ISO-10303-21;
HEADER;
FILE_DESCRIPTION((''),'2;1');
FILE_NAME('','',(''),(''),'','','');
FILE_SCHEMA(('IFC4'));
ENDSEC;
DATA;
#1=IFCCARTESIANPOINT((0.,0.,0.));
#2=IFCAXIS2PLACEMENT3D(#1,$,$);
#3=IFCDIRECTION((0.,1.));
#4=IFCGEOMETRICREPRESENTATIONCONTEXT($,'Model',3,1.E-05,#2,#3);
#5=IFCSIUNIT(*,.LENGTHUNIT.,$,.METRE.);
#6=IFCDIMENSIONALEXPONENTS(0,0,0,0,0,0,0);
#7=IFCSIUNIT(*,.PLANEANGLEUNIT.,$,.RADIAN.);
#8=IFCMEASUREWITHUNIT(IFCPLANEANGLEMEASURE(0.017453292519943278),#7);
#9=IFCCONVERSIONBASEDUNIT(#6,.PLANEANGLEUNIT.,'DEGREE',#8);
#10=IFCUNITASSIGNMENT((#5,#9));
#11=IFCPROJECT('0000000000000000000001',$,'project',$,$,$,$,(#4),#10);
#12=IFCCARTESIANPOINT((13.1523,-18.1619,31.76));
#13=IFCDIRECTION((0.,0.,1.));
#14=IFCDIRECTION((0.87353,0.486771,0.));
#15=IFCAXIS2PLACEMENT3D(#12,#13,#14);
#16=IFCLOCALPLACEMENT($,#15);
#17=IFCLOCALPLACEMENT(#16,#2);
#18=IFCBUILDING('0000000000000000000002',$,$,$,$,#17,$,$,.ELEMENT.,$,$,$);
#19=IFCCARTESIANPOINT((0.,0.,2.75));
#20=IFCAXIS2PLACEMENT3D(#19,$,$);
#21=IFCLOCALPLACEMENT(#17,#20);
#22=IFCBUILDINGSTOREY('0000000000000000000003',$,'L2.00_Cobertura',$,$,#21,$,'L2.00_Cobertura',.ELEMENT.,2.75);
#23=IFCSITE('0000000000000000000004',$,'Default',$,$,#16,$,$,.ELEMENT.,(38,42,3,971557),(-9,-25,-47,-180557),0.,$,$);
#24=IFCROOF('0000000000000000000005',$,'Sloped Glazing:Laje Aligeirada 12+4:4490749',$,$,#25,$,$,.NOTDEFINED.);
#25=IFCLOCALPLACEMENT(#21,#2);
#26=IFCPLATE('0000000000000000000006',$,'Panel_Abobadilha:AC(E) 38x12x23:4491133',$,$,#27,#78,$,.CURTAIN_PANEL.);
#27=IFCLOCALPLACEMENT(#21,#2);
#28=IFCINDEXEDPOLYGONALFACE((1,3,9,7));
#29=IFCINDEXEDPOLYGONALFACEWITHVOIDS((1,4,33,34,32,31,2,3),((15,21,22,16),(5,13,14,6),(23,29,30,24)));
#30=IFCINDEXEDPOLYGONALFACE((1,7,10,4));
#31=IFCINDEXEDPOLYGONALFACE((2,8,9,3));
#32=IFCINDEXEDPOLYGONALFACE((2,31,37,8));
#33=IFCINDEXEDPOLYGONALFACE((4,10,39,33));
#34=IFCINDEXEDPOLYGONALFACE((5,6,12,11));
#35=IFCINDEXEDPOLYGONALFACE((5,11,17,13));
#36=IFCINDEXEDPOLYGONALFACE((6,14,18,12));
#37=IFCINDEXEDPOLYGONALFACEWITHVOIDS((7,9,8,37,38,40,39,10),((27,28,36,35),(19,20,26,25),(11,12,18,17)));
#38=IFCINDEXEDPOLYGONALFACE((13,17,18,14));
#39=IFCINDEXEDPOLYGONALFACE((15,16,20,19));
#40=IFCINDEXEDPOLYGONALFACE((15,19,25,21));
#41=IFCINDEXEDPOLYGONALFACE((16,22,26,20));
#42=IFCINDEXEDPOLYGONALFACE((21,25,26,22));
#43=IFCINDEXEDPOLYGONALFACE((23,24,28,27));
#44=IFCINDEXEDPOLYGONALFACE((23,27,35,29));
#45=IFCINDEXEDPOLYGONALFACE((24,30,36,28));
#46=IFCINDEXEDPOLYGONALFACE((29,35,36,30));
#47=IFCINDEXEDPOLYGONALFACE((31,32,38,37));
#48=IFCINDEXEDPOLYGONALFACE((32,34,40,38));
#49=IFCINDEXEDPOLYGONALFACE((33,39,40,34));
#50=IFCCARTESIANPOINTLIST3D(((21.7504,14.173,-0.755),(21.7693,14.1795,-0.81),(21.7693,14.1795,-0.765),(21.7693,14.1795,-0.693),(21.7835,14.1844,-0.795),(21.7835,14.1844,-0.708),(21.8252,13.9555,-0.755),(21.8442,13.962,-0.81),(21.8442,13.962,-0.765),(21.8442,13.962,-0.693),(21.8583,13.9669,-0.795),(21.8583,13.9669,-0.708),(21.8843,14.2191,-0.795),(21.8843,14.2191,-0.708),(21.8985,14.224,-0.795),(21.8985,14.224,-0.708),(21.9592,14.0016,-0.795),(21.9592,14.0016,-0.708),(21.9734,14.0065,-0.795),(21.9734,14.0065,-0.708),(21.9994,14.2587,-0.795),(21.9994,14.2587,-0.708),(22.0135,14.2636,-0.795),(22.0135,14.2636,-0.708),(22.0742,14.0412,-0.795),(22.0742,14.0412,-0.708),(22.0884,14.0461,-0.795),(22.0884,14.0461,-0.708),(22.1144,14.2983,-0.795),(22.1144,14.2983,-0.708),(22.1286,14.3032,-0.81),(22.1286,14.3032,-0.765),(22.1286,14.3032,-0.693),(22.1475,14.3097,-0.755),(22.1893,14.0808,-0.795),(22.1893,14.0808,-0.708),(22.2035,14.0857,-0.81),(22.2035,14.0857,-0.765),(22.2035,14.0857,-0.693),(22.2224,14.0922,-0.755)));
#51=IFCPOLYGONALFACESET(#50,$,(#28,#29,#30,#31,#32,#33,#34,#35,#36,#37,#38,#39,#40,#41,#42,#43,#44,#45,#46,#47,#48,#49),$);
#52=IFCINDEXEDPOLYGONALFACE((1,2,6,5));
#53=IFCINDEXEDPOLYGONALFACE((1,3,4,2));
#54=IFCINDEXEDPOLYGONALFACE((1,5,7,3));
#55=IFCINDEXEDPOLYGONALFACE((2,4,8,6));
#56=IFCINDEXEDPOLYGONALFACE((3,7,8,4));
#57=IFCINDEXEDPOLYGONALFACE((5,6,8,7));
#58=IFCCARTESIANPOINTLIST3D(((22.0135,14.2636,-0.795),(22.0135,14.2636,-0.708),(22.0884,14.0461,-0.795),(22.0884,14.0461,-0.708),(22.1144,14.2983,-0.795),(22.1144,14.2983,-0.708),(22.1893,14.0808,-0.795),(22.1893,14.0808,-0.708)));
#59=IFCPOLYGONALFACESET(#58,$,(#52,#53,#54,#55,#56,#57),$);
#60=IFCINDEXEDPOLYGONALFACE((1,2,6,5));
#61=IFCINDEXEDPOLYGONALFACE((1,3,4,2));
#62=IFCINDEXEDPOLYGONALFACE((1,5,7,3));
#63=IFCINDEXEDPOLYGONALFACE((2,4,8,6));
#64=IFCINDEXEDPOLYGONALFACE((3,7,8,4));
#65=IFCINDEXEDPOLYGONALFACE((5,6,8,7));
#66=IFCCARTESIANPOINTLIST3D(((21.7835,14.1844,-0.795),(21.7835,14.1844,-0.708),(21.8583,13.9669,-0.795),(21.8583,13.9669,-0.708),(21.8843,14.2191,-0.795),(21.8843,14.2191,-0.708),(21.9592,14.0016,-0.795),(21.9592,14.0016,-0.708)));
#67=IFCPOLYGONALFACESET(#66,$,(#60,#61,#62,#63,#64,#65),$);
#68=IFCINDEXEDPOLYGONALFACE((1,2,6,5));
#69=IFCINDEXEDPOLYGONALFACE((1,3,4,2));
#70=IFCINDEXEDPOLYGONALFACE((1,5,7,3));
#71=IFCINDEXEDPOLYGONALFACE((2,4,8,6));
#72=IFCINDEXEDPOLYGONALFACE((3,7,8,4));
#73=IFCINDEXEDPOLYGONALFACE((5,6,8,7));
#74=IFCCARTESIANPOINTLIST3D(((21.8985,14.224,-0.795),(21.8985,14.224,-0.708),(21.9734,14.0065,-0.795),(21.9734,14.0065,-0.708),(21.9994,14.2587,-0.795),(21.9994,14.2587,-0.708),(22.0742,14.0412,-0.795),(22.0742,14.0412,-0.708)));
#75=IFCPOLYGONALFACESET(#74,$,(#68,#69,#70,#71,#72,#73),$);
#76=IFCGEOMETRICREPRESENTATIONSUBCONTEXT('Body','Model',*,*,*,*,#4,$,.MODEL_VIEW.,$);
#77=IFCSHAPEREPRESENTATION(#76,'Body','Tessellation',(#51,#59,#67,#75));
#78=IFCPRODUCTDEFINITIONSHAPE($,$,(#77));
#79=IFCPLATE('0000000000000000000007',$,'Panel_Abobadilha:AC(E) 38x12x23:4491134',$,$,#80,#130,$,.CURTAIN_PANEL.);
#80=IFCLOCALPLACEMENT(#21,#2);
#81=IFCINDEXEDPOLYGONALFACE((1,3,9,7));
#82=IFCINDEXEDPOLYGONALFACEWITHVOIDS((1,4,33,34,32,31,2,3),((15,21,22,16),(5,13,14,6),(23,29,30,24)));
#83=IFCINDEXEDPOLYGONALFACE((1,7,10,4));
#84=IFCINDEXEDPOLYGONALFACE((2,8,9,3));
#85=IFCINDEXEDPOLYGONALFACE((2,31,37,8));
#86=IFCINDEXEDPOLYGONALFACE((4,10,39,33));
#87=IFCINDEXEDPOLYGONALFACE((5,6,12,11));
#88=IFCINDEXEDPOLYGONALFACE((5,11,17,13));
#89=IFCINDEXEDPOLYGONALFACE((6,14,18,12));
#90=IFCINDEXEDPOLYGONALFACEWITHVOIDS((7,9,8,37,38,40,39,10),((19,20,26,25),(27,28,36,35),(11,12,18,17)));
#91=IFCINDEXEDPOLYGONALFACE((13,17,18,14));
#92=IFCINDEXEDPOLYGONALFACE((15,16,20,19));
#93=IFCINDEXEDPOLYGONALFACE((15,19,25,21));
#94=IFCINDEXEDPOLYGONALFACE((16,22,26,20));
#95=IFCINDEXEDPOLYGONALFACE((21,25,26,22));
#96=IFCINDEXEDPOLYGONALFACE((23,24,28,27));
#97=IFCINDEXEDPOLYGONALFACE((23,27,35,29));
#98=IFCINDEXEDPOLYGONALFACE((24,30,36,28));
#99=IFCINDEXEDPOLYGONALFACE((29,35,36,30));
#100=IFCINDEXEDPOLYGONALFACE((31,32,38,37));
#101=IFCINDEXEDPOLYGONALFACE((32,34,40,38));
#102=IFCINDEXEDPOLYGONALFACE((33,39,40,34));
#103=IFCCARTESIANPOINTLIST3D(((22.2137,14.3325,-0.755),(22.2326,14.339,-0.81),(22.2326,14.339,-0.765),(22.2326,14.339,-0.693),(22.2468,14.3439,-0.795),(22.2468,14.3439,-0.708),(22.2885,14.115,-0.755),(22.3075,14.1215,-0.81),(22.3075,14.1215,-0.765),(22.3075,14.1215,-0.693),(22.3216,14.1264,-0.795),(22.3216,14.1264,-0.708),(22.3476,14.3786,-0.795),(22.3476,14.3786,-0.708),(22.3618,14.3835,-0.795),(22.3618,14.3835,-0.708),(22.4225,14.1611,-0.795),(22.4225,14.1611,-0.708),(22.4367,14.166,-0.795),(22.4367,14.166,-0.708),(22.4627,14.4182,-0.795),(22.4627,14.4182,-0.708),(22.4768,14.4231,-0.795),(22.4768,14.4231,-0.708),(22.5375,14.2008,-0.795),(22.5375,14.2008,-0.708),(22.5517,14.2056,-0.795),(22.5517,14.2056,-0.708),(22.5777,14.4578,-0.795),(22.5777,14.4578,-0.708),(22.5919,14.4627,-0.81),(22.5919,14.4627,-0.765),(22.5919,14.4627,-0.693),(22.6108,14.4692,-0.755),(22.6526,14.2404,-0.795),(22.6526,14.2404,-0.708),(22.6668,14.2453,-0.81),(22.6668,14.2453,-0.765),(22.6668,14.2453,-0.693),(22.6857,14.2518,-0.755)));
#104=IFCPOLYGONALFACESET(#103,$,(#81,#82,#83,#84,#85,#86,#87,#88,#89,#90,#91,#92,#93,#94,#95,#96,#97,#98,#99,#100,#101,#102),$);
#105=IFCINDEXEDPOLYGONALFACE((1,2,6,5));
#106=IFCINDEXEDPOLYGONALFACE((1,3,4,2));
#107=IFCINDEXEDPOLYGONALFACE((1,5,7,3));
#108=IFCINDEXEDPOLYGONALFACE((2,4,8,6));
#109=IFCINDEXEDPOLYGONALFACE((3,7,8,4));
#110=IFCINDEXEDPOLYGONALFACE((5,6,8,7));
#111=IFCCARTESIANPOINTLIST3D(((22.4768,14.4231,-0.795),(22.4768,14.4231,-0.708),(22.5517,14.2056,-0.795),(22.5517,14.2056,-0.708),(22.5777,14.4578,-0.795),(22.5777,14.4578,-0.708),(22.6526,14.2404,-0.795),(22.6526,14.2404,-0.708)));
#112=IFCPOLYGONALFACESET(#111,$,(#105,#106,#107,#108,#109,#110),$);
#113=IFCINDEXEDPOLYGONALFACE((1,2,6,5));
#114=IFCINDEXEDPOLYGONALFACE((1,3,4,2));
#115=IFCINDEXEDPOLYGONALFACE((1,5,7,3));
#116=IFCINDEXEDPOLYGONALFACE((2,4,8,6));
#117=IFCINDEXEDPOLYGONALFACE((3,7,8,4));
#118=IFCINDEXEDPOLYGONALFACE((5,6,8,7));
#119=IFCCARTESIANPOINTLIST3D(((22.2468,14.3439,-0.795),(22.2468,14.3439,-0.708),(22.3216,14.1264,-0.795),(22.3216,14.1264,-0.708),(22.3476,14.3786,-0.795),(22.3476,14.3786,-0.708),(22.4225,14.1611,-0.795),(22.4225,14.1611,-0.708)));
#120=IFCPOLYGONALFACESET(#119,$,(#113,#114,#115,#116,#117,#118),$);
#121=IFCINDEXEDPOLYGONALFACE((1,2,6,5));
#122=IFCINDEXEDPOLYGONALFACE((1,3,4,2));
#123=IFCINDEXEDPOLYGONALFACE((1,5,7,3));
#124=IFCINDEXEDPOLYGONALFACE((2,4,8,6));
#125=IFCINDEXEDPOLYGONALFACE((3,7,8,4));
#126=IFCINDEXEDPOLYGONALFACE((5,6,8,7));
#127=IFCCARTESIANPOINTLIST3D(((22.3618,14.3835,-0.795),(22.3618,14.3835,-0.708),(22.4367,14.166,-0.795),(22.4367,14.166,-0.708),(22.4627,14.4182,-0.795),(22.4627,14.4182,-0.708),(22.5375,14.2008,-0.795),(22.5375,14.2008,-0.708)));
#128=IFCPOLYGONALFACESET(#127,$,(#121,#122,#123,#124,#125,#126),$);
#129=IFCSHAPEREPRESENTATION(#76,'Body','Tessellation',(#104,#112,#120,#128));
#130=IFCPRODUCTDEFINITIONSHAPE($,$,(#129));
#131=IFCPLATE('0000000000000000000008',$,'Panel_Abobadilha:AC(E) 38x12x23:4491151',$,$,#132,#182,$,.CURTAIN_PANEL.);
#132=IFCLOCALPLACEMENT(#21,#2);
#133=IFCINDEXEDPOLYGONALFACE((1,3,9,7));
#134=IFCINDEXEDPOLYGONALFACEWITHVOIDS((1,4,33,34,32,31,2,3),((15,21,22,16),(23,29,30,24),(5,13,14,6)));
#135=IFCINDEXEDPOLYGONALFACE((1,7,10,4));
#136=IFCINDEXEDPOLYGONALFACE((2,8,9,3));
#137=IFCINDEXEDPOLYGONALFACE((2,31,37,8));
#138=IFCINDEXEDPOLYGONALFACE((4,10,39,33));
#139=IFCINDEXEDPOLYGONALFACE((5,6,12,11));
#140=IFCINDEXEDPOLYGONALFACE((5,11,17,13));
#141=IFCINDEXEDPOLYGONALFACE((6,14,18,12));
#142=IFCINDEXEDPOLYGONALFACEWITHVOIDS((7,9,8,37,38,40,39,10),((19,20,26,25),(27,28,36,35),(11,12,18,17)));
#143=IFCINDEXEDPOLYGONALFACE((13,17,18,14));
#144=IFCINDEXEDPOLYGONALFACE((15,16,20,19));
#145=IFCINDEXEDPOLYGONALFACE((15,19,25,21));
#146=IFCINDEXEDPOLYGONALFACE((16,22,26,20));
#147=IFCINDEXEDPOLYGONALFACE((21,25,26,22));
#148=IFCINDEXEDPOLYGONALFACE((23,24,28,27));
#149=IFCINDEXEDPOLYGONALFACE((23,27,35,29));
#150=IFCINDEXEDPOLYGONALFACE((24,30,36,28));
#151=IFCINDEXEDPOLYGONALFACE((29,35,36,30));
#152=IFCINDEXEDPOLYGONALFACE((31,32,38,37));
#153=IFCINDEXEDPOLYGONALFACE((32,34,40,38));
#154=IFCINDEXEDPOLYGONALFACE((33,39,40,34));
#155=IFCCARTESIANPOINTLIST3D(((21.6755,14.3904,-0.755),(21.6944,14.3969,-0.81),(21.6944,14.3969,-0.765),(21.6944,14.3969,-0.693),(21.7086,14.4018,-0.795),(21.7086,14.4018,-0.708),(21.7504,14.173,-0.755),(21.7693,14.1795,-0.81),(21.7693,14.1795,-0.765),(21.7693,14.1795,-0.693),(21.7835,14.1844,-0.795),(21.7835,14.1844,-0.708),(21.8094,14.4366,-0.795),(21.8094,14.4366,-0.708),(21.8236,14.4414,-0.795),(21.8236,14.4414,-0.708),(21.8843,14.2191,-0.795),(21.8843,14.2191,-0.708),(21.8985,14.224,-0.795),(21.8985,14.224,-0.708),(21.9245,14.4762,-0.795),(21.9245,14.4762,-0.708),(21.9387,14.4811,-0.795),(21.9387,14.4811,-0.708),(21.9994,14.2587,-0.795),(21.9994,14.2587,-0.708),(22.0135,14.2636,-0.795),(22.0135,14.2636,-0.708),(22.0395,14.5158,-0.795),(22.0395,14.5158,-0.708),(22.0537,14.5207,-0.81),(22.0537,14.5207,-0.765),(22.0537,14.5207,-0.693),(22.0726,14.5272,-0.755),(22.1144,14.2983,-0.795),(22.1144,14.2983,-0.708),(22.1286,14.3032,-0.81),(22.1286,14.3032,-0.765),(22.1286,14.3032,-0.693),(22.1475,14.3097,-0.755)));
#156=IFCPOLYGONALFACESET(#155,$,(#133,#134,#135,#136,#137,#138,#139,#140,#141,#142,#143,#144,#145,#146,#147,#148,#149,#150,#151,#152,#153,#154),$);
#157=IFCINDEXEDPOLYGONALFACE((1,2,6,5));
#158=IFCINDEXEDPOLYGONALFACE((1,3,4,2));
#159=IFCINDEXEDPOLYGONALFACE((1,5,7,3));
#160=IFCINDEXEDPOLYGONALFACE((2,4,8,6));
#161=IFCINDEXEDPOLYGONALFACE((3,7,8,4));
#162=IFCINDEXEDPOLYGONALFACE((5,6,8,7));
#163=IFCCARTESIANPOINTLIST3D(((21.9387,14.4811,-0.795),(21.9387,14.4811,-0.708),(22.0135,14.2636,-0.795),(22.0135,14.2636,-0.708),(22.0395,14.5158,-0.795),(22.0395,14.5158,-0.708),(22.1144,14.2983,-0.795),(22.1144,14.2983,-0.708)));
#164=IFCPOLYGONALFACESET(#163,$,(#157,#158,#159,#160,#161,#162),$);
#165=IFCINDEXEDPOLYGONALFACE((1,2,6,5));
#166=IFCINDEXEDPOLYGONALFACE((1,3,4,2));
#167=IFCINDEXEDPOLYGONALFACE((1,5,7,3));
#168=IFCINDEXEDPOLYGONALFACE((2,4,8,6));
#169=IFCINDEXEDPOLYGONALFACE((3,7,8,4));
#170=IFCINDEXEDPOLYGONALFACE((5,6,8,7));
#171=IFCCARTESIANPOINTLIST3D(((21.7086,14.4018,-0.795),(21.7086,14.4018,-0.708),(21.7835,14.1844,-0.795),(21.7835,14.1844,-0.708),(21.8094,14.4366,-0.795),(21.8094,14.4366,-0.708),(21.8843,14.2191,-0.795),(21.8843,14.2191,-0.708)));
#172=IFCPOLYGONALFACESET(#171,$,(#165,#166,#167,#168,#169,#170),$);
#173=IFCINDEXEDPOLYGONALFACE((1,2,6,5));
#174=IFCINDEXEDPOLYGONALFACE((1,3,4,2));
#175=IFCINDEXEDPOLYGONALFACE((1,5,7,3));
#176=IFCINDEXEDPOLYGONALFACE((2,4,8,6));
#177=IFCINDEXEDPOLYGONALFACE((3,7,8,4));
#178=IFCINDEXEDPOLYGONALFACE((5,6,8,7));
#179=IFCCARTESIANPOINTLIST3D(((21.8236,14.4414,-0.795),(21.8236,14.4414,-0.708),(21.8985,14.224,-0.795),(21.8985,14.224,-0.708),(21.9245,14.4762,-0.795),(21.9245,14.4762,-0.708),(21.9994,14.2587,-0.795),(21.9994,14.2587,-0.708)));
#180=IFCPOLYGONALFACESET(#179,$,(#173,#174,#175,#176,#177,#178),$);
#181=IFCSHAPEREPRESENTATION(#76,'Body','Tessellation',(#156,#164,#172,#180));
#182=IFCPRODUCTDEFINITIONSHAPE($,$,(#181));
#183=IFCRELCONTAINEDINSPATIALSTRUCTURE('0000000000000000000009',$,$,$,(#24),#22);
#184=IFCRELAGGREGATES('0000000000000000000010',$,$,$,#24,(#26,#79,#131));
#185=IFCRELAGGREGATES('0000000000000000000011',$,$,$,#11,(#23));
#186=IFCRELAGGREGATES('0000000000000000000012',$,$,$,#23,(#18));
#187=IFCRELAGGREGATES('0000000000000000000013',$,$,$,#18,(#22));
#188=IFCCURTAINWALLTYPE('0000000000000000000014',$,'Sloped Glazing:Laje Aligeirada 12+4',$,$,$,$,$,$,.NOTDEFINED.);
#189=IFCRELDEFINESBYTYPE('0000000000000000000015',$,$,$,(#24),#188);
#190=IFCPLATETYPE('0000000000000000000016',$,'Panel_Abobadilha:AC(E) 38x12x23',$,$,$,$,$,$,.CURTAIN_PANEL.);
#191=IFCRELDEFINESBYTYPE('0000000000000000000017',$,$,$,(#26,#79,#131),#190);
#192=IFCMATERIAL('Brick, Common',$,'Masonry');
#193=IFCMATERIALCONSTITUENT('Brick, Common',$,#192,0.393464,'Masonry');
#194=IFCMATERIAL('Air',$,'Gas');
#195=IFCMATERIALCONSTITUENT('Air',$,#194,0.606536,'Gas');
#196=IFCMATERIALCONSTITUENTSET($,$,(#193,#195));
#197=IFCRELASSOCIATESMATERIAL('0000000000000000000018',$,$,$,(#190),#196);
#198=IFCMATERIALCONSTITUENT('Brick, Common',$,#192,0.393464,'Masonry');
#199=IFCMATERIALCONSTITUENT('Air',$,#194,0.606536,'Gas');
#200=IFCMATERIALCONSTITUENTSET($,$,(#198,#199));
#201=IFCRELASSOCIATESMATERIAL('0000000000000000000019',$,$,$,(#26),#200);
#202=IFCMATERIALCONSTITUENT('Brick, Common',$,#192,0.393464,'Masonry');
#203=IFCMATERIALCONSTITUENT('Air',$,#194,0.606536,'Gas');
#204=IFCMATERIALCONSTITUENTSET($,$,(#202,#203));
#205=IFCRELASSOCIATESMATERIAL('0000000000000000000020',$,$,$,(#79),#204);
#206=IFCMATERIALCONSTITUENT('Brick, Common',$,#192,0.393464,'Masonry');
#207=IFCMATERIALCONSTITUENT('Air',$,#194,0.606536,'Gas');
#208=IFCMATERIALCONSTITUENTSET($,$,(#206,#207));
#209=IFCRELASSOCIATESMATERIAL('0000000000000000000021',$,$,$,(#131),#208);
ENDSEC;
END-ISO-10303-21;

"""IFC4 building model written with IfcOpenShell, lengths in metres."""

from ifc_helpers import new_model, entity, si_unit, converted_unit, direction, frame, origin, place, context, subcontext, project, spatial, indexed_curve, outline, extrude, source, transform, mapped, material, constituent, constituent_set, type_object, type_shapes, element, aggregate, save


model = new_model("IFC4")

# Units and contexts
model_context = context("Model", 3, precision=1e-05, world=origin(), true_north=direction((0.0, 1.0)))
body_context = subcontext(model_context, "Body", "Model", "MODEL_VIEW")
ifc_project = project(units=[si_unit("LENGTHUNIT", "METRE"), converted_unit("PLANEANGLEUNIT", "DEGREE", entity("IfcPlaneAngleMeasure", 0.017453292519943278), si_unit("PLANEANGLEUNIT", "RADIAN"), dimensions=[0, 0, 0, 0, 0, 0, 0])], contexts=[model_context])

# Site, building, storey
site_placement = place(None, frame((13.1523, -18.1619, 31.76), z_axis=(0.0, 0.0, 1.0), x_axis=(0.87353, 0.486771, 0.0)))
site = spatial("IfcSite", under=ifc_project, at=site_placement, Name="Default", CompositionType="ELEMENT", RefLatitude=(38, 42, 3, 971557), RefLongitude=(-9, -25, -47, -180557), RefElevation=0.0)
building_placement = place(site_placement, origin())
building = spatial("IfcBuilding", under=site, at=building_placement, CompositionType="ELEMENT")
storey_placement = place(building_placement, frame((0.0, 0.0, 2.75)))
storey = spatial("IfcBuildingStorey", under=building, at=storey_placement, Name="L2.00_Cobertura", LongName="L2.00_Cobertura", CompositionType="ELEMENT", Elevation=2.75)

# Roof, plates
curtain_wall_type = type_object("IfcCurtainWallType", Name="Sloped Glazing:Laje Aligeirada 12+4", PredefinedType="NOTDEFINED")
roof_placement = place(storey_placement, frame((0.0, 0.0, -2.75)))
roof = element("IfcRoof", 1, at=roof_placement, inside=storey, type_object=curtain_wall_type, Name="Sloped Glazing:Laje Aligeirada 12+4:4490749", PredefinedType="NOTDEFINED")
ifc_material_1 = material(Name="Brick, Common", Category="Masonry")
ifc_material_2 = material(Name="Air", Category="Gas")
ifc_constituent_1 = constituent(ifc_material_1, Name="Brick, Common", Category="Masonry", fraction=0.393464)
ifc_constituent_2 = constituent(ifc_material_2, Name="Air", Category="Gas", fraction=0.606536)
ifc_constituent_set_1 = constituent_set(constituents=[ifc_constituent_1, ifc_constituent_2])
plate_type = type_object("IfcPlateType", Name="Panel_Abobadilha:AC(E) 38x12x23", PredefinedType="CURTAIN_PANEL", material=ifc_constituent_set_1)
shared_shape_1 = source(origin(), body_context, "Body", "SweptSolid", [
    extrude(outline(indexed_curve([(-0.19, -0.0543), (0.19, -0.0543), (0.19, -0.0093), (0.21, 0.0007), (0.19, 0.0628), (-0.19, 0.0628), (-0.21, 0.0007), (-0.19, -0.0093), (-0.19, -0.0543)], self_intersect=False), holes=[indexed_curve([(-0.0683, 0.0477), (-0.0683, -0.0393), (-0.175, -0.0393), (-0.175, 0.0477), (-0.0683, 0.0477)], self_intersect=False), indexed_curve([(0.0533, 0.0477), (0.0533, -0.0393), (-0.0533, -0.0393), (-0.0533, 0.0477), (0.0533, 0.0477)], self_intersect=False), indexed_curve([(0.175, 0.0477), (0.175, -0.0393), (0.0683, -0.0393), (0.0683, 0.0477), (0.175, 0.0477)], self_intersect=False)]), frame((0.0, 0.0543, 0.0)), (0.0, 0.0, 1.0), 0.23),
    extrude(outline(indexed_curve([(-0.0533, -0.0435), (0.0533, -0.0435), (0.0533, 0.0435), (-0.0533, 0.0435), (-0.0533, -0.0435)], self_intersect=False)), frame((0.1217, 0.0585, 0.0), z_axis=(0.0, 0.0, 1.0), x_axis=(-1.0, 0.0, 0.0)), (0.0, 0.0, 1.0), 0.23),
    extrude(outline(indexed_curve([(-0.0533, -0.0435), (0.0533, -0.0435), (0.0533, 0.0435), (-0.0533, 0.0435), (-0.0533, -0.0435)], self_intersect=False)), frame((-0.1217, 0.0585, 0.0), z_axis=(0.0, 0.0, 1.0), x_axis=(-1.0, 0.0, 0.0)), (0.0, 0.0, 1.0), 0.23),
    extrude(outline(indexed_curve([(-0.0533, -0.0435), (0.0533, -0.0435), (0.0533, 0.0435), (-0.0533, 0.0435), (-0.0533, -0.0435)], self_intersect=False)), frame((0.0, 0.0585, 0.0), z_axis=(0.0, 0.0, 1.0), x_axis=(-1.0, 0.0, 0.0)), (0.0, 0.0, 1.0), 0.23),
])
type_shapes(plate_type, [shared_shape_1])
ifc_constituent_3 = constituent(ifc_material_1, Name="Brick, Common", Category="Masonry", fraction=0.393464)
ifc_constituent_4 = constituent(ifc_material_2, Name="Air", Category="Gas", fraction=0.606536)
ifc_constituent_set_2 = constituent_set(constituents=[ifc_constituent_3, ifc_constituent_4])
plate_1_placement = place(roof_placement, frame((21.9489, 14.2413, 1.94), z_axis=(0.325568, -0.945519, 0.0), x_axis=(0.945519, 0.325568, 0.0)))
plate_1 = element("IfcPlate", 2, at=plate_1_placement, type_object=plate_type, material=ifc_constituent_set_2, Name="Panel_Abobadilha:AC(E) 38x12x23:4491133", PredefinedType="CURTAIN_PANEL", context=body_context, shape_type="MappedRepresentation", body=[
    mapped(shared_shape_1, transform((0.0, 0.0, 0.0), scale=1.0)),
])
ifc_constituent_5 = constituent(ifc_material_1, Name="Brick, Common", Category="Masonry", fraction=0.393464)
ifc_constituent_6 = constituent(ifc_material_2, Name="Air", Category="Gas", fraction=0.606536)
ifc_constituent_set_3 = constituent_set(constituents=[ifc_constituent_5, ifc_constituent_6])
plate_2_placement = place(roof_placement, frame((22.4122, 14.4009, 1.94), z_axis=(0.325568, -0.945519, 0.0), x_axis=(0.945519, 0.325568, 0.0)))
plate_2 = element("IfcPlate", 3, at=plate_2_placement, type_object=plate_type, material=ifc_constituent_set_3, Name="Panel_Abobadilha:AC(E) 38x12x23:4491134", PredefinedType="CURTAIN_PANEL", context=body_context, shape_type="MappedRepresentation", body=[
    mapped(shared_shape_1, transform((0.0, 0.0, 0.0), scale=1.0)),
])
ifc_constituent_7 = constituent(ifc_material_1, Name="Brick, Common", Category="Masonry", fraction=0.393464)
ifc_constituent_8 = constituent(ifc_material_2, Name="Air", Category="Gas", fraction=0.606536)
ifc_constituent_set_4 = constituent_set(constituents=[ifc_constituent_7, ifc_constituent_8])
plate_3_placement = place(roof_placement, frame((21.874, 14.4588, 1.94), z_axis=(0.325568, -0.945519, 0.0), x_axis=(0.945519, 0.325568, 0.0)))
plate_3 = element("IfcPlate", 4, at=plate_3_placement, type_object=plate_type, material=ifc_constituent_set_4, Name="Panel_Abobadilha:AC(E) 38x12x23:4491151", PredefinedType="CURTAIN_PANEL", context=body_context, shape_type="MappedRepresentation", body=[
    mapped(shared_shape_1, transform((0.0, 0.0, 0.0), scale=1.0)),
])
aggregate(roof, [plate_1, plate_2, plate_3])

save(model, "model.ifc")
